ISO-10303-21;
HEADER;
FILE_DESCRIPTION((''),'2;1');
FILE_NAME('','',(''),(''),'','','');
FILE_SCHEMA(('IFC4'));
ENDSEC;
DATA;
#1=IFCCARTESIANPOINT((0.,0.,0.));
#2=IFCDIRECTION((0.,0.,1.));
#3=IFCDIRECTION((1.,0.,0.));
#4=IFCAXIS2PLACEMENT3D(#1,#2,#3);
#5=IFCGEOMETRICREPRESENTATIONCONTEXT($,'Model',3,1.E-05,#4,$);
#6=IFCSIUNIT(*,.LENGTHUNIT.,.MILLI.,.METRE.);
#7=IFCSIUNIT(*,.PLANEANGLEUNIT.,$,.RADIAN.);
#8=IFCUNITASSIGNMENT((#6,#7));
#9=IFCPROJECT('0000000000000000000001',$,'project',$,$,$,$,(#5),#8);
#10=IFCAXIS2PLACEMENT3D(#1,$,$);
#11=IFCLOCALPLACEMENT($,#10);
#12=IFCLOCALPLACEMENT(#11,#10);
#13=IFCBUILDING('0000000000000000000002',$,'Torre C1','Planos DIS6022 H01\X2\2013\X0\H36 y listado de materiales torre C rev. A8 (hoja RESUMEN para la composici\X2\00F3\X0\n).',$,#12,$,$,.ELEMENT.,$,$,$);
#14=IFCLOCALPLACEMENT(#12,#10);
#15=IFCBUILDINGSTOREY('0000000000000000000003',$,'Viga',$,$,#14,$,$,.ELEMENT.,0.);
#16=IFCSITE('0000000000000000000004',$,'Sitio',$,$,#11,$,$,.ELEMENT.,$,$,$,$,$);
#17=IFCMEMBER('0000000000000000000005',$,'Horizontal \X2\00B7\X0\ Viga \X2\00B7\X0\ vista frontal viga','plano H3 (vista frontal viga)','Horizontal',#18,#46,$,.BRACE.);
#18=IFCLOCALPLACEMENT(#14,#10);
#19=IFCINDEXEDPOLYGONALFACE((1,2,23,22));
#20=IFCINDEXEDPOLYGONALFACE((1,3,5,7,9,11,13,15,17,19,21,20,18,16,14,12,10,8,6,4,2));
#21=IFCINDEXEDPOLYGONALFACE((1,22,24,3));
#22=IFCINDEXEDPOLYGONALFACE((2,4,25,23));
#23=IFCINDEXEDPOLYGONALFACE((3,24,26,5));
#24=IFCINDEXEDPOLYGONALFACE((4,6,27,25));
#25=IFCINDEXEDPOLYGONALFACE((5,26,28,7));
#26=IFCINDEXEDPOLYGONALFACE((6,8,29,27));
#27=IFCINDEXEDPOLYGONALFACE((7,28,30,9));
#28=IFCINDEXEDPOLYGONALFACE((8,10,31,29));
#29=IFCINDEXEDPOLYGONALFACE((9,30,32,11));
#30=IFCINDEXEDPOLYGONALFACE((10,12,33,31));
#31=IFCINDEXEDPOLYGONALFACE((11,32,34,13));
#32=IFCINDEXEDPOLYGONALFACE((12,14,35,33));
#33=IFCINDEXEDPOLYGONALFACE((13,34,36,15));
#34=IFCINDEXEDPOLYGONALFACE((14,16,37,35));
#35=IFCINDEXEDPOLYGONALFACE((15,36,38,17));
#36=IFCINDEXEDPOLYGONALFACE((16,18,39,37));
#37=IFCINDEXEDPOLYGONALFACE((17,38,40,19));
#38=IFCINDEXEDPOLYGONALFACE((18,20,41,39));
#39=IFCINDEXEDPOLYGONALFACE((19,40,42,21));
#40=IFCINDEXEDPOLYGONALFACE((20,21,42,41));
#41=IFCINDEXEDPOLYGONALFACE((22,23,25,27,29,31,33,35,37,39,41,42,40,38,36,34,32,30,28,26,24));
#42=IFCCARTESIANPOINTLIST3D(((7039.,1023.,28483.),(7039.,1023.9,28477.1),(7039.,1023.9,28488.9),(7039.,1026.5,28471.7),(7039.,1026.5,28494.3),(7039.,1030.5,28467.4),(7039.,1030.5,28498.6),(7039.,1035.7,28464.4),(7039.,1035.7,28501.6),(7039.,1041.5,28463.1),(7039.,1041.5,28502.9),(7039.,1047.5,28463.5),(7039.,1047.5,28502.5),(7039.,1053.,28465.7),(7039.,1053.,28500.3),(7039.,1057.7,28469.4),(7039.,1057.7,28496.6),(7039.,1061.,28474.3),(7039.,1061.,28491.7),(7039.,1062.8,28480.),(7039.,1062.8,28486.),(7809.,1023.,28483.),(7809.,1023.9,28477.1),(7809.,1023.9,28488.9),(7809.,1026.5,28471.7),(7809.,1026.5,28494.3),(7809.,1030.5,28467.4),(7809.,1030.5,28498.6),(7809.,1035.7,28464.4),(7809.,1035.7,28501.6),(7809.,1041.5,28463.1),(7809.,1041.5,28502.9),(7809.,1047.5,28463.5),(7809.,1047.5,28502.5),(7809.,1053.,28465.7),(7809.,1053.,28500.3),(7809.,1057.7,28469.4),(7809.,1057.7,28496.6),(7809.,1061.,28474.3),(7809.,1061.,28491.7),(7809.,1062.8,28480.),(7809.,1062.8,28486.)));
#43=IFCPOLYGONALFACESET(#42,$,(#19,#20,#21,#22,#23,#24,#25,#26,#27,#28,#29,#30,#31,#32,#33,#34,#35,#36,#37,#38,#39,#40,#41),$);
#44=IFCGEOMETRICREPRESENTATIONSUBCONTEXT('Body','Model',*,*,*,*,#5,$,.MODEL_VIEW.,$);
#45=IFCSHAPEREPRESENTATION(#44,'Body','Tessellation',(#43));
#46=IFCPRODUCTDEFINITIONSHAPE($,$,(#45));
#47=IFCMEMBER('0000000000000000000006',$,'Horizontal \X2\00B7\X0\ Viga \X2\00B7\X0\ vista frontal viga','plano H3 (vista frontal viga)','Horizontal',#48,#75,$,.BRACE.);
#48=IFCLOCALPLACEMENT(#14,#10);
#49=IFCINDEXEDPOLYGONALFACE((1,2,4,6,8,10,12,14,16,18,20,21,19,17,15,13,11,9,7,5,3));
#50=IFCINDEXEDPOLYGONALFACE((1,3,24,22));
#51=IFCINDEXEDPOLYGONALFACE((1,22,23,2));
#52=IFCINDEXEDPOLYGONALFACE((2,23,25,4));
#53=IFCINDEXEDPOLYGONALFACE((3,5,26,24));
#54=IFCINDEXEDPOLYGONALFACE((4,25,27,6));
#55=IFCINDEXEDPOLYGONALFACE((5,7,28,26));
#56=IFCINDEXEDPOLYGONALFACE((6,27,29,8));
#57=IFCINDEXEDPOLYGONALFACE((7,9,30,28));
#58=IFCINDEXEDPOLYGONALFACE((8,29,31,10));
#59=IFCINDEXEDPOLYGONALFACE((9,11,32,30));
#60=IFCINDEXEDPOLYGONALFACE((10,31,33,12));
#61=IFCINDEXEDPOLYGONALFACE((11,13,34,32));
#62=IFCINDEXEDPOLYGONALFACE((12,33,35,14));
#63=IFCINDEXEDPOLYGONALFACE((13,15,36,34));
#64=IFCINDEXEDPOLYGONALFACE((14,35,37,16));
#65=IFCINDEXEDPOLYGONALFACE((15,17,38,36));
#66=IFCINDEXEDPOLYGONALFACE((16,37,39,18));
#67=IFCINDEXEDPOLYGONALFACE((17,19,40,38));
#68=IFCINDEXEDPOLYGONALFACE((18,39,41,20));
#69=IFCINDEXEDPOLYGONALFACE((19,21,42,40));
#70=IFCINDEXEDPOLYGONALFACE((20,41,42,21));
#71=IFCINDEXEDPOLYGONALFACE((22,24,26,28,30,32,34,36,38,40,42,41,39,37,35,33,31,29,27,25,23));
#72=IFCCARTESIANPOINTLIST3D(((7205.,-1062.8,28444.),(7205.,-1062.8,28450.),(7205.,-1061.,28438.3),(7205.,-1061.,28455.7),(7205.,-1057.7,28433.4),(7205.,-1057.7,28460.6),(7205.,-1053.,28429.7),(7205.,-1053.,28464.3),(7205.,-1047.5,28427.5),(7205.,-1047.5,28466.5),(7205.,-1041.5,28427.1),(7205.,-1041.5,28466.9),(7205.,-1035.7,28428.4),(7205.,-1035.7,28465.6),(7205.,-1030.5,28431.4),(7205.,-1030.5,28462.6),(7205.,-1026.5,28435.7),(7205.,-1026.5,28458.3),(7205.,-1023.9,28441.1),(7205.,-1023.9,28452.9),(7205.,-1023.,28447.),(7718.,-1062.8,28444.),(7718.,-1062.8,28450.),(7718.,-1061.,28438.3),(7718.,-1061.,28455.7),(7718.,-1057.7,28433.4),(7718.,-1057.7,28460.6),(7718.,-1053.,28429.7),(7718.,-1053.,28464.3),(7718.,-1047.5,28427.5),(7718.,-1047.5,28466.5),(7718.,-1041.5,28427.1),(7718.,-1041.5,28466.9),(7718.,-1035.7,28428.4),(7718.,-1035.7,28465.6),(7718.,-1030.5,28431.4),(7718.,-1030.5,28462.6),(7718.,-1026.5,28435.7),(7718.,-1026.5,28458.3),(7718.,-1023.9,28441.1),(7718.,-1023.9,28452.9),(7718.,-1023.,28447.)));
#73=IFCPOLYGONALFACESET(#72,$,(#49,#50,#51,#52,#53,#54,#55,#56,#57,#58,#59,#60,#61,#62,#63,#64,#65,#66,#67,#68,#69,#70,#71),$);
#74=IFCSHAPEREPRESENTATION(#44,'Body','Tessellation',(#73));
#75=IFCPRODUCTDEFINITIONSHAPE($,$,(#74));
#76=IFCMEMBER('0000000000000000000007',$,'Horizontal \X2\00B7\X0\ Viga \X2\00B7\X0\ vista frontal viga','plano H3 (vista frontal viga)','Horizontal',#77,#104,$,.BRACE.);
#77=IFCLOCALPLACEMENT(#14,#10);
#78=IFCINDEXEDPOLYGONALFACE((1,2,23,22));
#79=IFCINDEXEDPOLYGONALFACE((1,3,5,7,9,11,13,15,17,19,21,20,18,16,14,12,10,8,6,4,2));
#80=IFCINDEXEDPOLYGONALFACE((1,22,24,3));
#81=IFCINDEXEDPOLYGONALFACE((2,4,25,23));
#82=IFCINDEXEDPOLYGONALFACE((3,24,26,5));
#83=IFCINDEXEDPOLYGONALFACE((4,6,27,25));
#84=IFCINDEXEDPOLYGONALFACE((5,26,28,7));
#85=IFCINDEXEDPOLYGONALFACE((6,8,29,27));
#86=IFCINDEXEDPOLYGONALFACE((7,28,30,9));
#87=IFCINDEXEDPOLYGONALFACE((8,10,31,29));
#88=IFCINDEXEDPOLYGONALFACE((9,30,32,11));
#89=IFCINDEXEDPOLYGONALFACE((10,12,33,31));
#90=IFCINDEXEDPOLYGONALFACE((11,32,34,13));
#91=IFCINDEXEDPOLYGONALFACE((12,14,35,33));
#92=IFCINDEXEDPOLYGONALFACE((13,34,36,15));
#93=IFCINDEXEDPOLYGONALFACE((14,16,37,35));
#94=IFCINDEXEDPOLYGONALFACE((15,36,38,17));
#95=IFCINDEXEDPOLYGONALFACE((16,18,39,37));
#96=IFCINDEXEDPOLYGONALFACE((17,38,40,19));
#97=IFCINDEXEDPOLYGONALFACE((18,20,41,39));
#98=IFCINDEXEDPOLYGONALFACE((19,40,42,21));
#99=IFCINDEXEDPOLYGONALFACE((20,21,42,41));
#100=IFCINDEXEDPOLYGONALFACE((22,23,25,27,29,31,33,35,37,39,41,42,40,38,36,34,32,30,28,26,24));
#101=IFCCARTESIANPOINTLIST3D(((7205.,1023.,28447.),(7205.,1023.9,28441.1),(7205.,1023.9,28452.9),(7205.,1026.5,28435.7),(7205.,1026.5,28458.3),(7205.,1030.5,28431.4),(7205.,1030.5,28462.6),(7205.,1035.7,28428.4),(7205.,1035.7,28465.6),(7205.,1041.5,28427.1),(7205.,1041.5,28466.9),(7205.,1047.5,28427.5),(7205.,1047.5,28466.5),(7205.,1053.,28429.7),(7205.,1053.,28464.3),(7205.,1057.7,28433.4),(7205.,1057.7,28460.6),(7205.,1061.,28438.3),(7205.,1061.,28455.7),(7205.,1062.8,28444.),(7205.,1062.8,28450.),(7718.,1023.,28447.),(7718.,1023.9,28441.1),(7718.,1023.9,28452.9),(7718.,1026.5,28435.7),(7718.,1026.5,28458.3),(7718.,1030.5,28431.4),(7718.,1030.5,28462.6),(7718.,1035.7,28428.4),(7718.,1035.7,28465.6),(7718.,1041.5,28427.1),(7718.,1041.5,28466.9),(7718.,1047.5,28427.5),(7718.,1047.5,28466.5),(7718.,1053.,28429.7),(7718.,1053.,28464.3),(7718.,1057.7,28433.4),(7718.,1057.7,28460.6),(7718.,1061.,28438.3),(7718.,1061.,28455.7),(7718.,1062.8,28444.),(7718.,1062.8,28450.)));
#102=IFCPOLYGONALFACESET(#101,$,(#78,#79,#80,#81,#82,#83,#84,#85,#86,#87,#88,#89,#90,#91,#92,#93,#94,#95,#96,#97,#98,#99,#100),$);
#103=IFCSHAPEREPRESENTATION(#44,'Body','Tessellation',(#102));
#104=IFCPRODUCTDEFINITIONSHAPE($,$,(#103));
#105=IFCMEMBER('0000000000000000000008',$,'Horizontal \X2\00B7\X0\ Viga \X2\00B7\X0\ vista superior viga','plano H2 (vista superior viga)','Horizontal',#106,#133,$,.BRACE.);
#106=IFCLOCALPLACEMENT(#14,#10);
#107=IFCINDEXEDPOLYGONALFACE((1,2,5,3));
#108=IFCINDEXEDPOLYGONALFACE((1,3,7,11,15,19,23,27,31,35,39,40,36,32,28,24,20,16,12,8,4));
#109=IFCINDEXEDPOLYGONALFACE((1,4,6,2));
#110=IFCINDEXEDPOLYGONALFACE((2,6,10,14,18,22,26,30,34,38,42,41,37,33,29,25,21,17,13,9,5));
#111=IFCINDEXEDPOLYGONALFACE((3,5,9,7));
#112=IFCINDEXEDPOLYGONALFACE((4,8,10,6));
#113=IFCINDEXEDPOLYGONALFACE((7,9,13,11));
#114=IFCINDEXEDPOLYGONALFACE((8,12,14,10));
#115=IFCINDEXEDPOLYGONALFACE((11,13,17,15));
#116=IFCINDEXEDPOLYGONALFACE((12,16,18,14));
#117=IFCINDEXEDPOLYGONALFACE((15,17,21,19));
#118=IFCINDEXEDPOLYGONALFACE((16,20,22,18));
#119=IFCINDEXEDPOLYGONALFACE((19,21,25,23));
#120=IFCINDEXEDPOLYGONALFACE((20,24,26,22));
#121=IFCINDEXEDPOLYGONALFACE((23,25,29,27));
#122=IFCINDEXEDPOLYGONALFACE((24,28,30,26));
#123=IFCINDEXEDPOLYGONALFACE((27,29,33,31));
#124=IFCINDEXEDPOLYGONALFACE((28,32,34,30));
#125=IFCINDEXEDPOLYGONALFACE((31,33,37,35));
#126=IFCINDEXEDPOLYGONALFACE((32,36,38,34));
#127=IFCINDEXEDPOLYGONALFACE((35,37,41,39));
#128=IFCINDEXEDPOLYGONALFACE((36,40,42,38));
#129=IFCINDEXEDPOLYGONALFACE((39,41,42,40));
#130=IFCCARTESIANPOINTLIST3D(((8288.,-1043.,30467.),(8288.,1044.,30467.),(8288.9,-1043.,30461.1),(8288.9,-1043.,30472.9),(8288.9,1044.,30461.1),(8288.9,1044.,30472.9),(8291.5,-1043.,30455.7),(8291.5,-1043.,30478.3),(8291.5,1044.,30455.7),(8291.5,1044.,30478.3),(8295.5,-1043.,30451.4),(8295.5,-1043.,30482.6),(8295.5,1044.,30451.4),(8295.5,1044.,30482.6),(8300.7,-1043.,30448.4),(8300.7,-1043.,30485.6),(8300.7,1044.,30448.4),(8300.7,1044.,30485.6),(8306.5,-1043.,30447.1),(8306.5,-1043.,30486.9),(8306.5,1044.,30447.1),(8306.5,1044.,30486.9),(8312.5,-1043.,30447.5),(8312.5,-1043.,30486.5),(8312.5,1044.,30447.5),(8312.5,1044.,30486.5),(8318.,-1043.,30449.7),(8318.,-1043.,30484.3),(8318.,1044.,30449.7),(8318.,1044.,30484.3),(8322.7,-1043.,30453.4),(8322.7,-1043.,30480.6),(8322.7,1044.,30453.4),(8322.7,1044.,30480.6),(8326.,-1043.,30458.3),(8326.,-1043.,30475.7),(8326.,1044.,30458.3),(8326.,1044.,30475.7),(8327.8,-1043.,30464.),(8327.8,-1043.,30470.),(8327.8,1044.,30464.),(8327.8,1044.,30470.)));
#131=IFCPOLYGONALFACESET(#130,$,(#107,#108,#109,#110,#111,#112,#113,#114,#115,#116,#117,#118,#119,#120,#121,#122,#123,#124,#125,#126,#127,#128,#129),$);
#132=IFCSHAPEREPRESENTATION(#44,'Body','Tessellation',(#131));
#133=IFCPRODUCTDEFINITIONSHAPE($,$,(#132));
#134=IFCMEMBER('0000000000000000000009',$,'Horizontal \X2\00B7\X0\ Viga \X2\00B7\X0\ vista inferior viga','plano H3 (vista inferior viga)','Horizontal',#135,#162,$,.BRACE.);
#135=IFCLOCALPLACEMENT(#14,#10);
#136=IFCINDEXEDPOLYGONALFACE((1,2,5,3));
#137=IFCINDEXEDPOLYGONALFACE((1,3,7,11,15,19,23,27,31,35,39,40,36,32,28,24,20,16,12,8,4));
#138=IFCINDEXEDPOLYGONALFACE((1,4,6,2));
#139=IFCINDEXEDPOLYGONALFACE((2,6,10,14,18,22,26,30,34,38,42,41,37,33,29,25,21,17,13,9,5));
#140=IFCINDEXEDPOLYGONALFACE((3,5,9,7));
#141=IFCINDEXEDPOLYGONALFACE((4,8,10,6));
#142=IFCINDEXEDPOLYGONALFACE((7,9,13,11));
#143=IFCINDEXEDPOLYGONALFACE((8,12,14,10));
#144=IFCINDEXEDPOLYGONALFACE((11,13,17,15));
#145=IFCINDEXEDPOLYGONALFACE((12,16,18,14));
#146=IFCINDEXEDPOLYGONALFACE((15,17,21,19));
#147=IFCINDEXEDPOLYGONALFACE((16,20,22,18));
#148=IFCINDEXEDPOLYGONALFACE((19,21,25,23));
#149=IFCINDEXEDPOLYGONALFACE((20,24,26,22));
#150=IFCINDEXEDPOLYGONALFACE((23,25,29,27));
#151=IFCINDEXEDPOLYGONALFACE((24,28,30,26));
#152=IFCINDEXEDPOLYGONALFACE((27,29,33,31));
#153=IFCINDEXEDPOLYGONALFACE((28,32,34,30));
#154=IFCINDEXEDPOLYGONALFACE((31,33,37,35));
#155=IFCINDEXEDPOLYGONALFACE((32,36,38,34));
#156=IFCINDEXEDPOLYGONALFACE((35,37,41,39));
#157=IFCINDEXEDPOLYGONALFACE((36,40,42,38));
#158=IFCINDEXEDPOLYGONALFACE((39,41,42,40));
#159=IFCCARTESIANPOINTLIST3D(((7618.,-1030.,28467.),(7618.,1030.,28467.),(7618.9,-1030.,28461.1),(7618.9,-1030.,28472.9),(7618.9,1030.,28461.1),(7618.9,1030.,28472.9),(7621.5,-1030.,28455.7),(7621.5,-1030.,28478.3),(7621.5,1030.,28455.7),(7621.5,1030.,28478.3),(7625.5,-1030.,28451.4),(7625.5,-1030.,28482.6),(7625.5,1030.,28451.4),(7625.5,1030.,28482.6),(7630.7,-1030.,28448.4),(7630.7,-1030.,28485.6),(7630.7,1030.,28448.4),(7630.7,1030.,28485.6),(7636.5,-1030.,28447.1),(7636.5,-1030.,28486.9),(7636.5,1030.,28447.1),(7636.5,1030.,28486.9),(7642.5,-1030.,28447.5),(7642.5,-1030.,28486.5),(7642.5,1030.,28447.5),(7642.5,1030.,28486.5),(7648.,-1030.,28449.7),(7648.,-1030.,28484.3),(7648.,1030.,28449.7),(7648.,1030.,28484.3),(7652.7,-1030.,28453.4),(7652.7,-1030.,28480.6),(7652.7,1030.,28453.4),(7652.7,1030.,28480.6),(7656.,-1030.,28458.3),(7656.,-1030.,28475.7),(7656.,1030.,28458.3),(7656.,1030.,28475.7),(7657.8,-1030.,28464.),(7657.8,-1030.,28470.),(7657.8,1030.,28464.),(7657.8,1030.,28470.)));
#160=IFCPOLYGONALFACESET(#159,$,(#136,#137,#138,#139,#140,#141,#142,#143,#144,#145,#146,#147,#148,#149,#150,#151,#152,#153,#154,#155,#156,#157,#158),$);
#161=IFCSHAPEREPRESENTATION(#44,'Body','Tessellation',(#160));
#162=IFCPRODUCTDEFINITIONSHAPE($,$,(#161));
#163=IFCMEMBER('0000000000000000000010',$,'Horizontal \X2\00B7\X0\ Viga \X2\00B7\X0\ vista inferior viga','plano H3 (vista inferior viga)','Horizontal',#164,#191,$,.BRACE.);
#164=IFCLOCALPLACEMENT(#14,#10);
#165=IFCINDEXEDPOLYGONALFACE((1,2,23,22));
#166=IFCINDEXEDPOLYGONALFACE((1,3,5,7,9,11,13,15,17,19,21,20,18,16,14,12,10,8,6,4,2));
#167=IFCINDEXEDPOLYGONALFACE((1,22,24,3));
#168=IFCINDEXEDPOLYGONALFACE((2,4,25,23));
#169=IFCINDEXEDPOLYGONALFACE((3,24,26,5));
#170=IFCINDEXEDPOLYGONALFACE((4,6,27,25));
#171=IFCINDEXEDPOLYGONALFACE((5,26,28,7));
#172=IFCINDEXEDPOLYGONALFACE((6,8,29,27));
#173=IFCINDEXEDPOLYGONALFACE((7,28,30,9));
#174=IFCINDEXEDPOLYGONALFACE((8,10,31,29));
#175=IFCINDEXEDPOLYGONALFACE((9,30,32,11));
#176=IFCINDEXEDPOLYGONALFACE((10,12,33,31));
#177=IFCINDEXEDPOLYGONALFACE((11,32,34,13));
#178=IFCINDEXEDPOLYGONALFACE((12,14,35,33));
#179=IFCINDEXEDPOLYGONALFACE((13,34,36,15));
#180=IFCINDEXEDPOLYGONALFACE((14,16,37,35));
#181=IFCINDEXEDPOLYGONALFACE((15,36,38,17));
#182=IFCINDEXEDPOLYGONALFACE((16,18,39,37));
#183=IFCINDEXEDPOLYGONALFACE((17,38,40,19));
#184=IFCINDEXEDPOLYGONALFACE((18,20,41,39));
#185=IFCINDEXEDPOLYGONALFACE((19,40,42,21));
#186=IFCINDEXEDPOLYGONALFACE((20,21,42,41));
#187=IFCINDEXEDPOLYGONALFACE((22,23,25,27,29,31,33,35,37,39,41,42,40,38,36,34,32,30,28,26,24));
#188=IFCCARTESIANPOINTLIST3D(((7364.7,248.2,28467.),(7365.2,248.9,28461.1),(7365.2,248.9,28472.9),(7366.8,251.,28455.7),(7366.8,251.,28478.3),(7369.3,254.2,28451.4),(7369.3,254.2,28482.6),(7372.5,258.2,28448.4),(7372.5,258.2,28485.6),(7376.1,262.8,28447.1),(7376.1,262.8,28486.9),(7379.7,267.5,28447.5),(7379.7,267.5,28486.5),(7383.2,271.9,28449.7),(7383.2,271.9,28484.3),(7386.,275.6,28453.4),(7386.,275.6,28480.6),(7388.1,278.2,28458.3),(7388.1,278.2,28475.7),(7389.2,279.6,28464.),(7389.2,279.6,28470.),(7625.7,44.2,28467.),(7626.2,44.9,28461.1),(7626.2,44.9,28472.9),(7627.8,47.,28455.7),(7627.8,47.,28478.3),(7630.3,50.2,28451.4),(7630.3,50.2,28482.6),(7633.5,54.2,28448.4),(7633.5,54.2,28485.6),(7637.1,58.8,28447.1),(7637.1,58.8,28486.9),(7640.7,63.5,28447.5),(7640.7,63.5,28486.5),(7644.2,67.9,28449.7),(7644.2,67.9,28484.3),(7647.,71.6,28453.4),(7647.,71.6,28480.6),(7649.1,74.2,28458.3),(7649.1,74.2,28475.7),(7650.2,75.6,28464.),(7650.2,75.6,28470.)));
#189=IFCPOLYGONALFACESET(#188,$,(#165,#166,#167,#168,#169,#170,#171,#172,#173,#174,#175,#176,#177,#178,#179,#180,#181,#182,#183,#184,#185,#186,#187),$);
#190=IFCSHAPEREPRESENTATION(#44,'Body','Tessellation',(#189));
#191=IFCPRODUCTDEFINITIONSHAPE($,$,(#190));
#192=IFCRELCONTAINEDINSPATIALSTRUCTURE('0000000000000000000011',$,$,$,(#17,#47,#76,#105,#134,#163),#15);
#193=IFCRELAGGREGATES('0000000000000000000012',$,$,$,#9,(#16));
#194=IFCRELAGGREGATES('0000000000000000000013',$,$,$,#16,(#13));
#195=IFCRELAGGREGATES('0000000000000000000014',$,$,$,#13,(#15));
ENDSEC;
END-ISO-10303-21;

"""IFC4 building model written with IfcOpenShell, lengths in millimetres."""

from ifc_helpers import new_model, si_unit, frame, origin, origin_with_axes, place, context, subcontext, project, spatial, circle, extrude, element, save


model = new_model("IFC4")

# Units and contexts
model_context = context("Model", 3, precision=1e-05, world=origin_with_axes())
body_context = subcontext(model_context, "Body", "Model", "MODEL_VIEW")
ifc_project = project(units=[si_unit("LENGTHUNIT", "METRE", prefix="MILLI"), si_unit("PLANEANGLEUNIT", "RADIAN")], contexts=[model_context])

# Site, building, storey
site_placement = place(None, origin())
site = spatial("IfcSite", under=ifc_project, at=site_placement, Name="Sitio", CompositionType="ELEMENT")
building_placement = place(site_placement, origin())
building = spatial("IfcBuilding", under=site, at=building_placement, Name="Torre C1", Description="Planos DIS6022 H01–H36 y listado de materiales torre C rev. A8 (hoja RESUMEN para la composición).", CompositionType="ELEMENT")
storey_placement = place(building_placement, origin())
storey = spatial("IfcBuildingStorey", under=building, at=storey_placement, Name="Viga", CompositionType="ELEMENT", Elevation=0.0)

# Members
for number, where, z_axis, x_axis, name in (
    (1, (7809.0, 1043.0, 28483.0), (-1.0, 0.0, 0.0), (0.0, -1.0, 0.0), "Horizontal · Viga · vista frontal viga"),
):
    element("IfcMember", number, at=place(storey_placement, frame(where, z_axis=z_axis, x_axis=x_axis)), inside=storey, Name=name, Description="plano H3 (vista frontal viga)", ObjectType="Horizontal", PredefinedType="BRACE", context=body_context, shape_type="SweptSolid", body=[
        extrude(circle(Radius=20.0), None, (0.0, 0.0, 1.0), 770.0),
    ])
for number, where, z_axis, x_axis, name in (
    (2, (7718.0, -1043.0, 28447.0), (-1.0, 0.0, 0.0), (0.0, 1.0, 0.0), "Horizontal · Viga · vista frontal viga"),
    (3, (7718.0, 1043.0, 28447.0), (-1.0, 0.0, 0.0), (0.0, -1.0, 0.0), "Horizontal · Viga · vista frontal viga"),
):
    element("IfcMember", number, at=place(storey_placement, frame(where, z_axis=z_axis, x_axis=x_axis)), inside=storey, Name=name, Description="plano H3 (vista frontal viga)", ObjectType="Horizontal", PredefinedType="BRACE", context=body_context, shape_type="SweptSolid", body=[
        extrude(circle(Radius=20.0), None, (0.0, 0.0, 1.0), 513.0),
    ])
member_1_placement = place(storey_placement, frame((8308.0, -1043.0, 30467.0), z_axis=(0.0, 1.0, 0.0), x_axis=(-1.0, 0.0, 0.0)))
element("IfcMember", 4, at=member_1_placement, inside=storey, Name="Horizontal · Viga · vista superior viga", Description="plano H2 (vista superior viga)", ObjectType="Horizontal", PredefinedType="BRACE", context=body_context, shape_type="SweptSolid", body=[
    extrude(circle(Radius=20.0), None, (0.0, 0.0, 1.0), 2087.0),
])
member_2_placement = place(storey_placement, frame((7638.0, 1030.0, 28467.0), z_axis=(0.0, -1.0, 0.0), x_axis=(-1.0, 0.0, 0.0)))
element("IfcMember", 5, at=member_2_placement, inside=storey, Name="Horizontal · Viga · vista inferior viga", Description="plano H3 (vista inferior viga)", ObjectType="Horizontal", PredefinedType="BRACE", context=body_context, shape_type="SweptSolid", body=[
    extrude(circle(Radius=20.0), None, (0.0, 0.0, 1.0), 2060.0),
])
member_3_placement = place(storey_placement, frame((7638.0, 60.0, 28467.0), z_axis=(-0.787887, 0.61582, 0.0), x_axis=(-0.61582, -0.787887, 0.0)))
element("IfcMember", 6, at=member_3_placement, inside=storey, Name="Horizontal · Viga · vista inferior viga", Description="plano H3 (vista inferior viga)", ObjectType="Horizontal", PredefinedType="BRACE", context=body_context, shape_type="SweptSolid", body=[
    extrude(circle(Radius=20.0), None, (0.0, 0.0, 1.0), 331.3),
])

save(model, "model.ifc")
